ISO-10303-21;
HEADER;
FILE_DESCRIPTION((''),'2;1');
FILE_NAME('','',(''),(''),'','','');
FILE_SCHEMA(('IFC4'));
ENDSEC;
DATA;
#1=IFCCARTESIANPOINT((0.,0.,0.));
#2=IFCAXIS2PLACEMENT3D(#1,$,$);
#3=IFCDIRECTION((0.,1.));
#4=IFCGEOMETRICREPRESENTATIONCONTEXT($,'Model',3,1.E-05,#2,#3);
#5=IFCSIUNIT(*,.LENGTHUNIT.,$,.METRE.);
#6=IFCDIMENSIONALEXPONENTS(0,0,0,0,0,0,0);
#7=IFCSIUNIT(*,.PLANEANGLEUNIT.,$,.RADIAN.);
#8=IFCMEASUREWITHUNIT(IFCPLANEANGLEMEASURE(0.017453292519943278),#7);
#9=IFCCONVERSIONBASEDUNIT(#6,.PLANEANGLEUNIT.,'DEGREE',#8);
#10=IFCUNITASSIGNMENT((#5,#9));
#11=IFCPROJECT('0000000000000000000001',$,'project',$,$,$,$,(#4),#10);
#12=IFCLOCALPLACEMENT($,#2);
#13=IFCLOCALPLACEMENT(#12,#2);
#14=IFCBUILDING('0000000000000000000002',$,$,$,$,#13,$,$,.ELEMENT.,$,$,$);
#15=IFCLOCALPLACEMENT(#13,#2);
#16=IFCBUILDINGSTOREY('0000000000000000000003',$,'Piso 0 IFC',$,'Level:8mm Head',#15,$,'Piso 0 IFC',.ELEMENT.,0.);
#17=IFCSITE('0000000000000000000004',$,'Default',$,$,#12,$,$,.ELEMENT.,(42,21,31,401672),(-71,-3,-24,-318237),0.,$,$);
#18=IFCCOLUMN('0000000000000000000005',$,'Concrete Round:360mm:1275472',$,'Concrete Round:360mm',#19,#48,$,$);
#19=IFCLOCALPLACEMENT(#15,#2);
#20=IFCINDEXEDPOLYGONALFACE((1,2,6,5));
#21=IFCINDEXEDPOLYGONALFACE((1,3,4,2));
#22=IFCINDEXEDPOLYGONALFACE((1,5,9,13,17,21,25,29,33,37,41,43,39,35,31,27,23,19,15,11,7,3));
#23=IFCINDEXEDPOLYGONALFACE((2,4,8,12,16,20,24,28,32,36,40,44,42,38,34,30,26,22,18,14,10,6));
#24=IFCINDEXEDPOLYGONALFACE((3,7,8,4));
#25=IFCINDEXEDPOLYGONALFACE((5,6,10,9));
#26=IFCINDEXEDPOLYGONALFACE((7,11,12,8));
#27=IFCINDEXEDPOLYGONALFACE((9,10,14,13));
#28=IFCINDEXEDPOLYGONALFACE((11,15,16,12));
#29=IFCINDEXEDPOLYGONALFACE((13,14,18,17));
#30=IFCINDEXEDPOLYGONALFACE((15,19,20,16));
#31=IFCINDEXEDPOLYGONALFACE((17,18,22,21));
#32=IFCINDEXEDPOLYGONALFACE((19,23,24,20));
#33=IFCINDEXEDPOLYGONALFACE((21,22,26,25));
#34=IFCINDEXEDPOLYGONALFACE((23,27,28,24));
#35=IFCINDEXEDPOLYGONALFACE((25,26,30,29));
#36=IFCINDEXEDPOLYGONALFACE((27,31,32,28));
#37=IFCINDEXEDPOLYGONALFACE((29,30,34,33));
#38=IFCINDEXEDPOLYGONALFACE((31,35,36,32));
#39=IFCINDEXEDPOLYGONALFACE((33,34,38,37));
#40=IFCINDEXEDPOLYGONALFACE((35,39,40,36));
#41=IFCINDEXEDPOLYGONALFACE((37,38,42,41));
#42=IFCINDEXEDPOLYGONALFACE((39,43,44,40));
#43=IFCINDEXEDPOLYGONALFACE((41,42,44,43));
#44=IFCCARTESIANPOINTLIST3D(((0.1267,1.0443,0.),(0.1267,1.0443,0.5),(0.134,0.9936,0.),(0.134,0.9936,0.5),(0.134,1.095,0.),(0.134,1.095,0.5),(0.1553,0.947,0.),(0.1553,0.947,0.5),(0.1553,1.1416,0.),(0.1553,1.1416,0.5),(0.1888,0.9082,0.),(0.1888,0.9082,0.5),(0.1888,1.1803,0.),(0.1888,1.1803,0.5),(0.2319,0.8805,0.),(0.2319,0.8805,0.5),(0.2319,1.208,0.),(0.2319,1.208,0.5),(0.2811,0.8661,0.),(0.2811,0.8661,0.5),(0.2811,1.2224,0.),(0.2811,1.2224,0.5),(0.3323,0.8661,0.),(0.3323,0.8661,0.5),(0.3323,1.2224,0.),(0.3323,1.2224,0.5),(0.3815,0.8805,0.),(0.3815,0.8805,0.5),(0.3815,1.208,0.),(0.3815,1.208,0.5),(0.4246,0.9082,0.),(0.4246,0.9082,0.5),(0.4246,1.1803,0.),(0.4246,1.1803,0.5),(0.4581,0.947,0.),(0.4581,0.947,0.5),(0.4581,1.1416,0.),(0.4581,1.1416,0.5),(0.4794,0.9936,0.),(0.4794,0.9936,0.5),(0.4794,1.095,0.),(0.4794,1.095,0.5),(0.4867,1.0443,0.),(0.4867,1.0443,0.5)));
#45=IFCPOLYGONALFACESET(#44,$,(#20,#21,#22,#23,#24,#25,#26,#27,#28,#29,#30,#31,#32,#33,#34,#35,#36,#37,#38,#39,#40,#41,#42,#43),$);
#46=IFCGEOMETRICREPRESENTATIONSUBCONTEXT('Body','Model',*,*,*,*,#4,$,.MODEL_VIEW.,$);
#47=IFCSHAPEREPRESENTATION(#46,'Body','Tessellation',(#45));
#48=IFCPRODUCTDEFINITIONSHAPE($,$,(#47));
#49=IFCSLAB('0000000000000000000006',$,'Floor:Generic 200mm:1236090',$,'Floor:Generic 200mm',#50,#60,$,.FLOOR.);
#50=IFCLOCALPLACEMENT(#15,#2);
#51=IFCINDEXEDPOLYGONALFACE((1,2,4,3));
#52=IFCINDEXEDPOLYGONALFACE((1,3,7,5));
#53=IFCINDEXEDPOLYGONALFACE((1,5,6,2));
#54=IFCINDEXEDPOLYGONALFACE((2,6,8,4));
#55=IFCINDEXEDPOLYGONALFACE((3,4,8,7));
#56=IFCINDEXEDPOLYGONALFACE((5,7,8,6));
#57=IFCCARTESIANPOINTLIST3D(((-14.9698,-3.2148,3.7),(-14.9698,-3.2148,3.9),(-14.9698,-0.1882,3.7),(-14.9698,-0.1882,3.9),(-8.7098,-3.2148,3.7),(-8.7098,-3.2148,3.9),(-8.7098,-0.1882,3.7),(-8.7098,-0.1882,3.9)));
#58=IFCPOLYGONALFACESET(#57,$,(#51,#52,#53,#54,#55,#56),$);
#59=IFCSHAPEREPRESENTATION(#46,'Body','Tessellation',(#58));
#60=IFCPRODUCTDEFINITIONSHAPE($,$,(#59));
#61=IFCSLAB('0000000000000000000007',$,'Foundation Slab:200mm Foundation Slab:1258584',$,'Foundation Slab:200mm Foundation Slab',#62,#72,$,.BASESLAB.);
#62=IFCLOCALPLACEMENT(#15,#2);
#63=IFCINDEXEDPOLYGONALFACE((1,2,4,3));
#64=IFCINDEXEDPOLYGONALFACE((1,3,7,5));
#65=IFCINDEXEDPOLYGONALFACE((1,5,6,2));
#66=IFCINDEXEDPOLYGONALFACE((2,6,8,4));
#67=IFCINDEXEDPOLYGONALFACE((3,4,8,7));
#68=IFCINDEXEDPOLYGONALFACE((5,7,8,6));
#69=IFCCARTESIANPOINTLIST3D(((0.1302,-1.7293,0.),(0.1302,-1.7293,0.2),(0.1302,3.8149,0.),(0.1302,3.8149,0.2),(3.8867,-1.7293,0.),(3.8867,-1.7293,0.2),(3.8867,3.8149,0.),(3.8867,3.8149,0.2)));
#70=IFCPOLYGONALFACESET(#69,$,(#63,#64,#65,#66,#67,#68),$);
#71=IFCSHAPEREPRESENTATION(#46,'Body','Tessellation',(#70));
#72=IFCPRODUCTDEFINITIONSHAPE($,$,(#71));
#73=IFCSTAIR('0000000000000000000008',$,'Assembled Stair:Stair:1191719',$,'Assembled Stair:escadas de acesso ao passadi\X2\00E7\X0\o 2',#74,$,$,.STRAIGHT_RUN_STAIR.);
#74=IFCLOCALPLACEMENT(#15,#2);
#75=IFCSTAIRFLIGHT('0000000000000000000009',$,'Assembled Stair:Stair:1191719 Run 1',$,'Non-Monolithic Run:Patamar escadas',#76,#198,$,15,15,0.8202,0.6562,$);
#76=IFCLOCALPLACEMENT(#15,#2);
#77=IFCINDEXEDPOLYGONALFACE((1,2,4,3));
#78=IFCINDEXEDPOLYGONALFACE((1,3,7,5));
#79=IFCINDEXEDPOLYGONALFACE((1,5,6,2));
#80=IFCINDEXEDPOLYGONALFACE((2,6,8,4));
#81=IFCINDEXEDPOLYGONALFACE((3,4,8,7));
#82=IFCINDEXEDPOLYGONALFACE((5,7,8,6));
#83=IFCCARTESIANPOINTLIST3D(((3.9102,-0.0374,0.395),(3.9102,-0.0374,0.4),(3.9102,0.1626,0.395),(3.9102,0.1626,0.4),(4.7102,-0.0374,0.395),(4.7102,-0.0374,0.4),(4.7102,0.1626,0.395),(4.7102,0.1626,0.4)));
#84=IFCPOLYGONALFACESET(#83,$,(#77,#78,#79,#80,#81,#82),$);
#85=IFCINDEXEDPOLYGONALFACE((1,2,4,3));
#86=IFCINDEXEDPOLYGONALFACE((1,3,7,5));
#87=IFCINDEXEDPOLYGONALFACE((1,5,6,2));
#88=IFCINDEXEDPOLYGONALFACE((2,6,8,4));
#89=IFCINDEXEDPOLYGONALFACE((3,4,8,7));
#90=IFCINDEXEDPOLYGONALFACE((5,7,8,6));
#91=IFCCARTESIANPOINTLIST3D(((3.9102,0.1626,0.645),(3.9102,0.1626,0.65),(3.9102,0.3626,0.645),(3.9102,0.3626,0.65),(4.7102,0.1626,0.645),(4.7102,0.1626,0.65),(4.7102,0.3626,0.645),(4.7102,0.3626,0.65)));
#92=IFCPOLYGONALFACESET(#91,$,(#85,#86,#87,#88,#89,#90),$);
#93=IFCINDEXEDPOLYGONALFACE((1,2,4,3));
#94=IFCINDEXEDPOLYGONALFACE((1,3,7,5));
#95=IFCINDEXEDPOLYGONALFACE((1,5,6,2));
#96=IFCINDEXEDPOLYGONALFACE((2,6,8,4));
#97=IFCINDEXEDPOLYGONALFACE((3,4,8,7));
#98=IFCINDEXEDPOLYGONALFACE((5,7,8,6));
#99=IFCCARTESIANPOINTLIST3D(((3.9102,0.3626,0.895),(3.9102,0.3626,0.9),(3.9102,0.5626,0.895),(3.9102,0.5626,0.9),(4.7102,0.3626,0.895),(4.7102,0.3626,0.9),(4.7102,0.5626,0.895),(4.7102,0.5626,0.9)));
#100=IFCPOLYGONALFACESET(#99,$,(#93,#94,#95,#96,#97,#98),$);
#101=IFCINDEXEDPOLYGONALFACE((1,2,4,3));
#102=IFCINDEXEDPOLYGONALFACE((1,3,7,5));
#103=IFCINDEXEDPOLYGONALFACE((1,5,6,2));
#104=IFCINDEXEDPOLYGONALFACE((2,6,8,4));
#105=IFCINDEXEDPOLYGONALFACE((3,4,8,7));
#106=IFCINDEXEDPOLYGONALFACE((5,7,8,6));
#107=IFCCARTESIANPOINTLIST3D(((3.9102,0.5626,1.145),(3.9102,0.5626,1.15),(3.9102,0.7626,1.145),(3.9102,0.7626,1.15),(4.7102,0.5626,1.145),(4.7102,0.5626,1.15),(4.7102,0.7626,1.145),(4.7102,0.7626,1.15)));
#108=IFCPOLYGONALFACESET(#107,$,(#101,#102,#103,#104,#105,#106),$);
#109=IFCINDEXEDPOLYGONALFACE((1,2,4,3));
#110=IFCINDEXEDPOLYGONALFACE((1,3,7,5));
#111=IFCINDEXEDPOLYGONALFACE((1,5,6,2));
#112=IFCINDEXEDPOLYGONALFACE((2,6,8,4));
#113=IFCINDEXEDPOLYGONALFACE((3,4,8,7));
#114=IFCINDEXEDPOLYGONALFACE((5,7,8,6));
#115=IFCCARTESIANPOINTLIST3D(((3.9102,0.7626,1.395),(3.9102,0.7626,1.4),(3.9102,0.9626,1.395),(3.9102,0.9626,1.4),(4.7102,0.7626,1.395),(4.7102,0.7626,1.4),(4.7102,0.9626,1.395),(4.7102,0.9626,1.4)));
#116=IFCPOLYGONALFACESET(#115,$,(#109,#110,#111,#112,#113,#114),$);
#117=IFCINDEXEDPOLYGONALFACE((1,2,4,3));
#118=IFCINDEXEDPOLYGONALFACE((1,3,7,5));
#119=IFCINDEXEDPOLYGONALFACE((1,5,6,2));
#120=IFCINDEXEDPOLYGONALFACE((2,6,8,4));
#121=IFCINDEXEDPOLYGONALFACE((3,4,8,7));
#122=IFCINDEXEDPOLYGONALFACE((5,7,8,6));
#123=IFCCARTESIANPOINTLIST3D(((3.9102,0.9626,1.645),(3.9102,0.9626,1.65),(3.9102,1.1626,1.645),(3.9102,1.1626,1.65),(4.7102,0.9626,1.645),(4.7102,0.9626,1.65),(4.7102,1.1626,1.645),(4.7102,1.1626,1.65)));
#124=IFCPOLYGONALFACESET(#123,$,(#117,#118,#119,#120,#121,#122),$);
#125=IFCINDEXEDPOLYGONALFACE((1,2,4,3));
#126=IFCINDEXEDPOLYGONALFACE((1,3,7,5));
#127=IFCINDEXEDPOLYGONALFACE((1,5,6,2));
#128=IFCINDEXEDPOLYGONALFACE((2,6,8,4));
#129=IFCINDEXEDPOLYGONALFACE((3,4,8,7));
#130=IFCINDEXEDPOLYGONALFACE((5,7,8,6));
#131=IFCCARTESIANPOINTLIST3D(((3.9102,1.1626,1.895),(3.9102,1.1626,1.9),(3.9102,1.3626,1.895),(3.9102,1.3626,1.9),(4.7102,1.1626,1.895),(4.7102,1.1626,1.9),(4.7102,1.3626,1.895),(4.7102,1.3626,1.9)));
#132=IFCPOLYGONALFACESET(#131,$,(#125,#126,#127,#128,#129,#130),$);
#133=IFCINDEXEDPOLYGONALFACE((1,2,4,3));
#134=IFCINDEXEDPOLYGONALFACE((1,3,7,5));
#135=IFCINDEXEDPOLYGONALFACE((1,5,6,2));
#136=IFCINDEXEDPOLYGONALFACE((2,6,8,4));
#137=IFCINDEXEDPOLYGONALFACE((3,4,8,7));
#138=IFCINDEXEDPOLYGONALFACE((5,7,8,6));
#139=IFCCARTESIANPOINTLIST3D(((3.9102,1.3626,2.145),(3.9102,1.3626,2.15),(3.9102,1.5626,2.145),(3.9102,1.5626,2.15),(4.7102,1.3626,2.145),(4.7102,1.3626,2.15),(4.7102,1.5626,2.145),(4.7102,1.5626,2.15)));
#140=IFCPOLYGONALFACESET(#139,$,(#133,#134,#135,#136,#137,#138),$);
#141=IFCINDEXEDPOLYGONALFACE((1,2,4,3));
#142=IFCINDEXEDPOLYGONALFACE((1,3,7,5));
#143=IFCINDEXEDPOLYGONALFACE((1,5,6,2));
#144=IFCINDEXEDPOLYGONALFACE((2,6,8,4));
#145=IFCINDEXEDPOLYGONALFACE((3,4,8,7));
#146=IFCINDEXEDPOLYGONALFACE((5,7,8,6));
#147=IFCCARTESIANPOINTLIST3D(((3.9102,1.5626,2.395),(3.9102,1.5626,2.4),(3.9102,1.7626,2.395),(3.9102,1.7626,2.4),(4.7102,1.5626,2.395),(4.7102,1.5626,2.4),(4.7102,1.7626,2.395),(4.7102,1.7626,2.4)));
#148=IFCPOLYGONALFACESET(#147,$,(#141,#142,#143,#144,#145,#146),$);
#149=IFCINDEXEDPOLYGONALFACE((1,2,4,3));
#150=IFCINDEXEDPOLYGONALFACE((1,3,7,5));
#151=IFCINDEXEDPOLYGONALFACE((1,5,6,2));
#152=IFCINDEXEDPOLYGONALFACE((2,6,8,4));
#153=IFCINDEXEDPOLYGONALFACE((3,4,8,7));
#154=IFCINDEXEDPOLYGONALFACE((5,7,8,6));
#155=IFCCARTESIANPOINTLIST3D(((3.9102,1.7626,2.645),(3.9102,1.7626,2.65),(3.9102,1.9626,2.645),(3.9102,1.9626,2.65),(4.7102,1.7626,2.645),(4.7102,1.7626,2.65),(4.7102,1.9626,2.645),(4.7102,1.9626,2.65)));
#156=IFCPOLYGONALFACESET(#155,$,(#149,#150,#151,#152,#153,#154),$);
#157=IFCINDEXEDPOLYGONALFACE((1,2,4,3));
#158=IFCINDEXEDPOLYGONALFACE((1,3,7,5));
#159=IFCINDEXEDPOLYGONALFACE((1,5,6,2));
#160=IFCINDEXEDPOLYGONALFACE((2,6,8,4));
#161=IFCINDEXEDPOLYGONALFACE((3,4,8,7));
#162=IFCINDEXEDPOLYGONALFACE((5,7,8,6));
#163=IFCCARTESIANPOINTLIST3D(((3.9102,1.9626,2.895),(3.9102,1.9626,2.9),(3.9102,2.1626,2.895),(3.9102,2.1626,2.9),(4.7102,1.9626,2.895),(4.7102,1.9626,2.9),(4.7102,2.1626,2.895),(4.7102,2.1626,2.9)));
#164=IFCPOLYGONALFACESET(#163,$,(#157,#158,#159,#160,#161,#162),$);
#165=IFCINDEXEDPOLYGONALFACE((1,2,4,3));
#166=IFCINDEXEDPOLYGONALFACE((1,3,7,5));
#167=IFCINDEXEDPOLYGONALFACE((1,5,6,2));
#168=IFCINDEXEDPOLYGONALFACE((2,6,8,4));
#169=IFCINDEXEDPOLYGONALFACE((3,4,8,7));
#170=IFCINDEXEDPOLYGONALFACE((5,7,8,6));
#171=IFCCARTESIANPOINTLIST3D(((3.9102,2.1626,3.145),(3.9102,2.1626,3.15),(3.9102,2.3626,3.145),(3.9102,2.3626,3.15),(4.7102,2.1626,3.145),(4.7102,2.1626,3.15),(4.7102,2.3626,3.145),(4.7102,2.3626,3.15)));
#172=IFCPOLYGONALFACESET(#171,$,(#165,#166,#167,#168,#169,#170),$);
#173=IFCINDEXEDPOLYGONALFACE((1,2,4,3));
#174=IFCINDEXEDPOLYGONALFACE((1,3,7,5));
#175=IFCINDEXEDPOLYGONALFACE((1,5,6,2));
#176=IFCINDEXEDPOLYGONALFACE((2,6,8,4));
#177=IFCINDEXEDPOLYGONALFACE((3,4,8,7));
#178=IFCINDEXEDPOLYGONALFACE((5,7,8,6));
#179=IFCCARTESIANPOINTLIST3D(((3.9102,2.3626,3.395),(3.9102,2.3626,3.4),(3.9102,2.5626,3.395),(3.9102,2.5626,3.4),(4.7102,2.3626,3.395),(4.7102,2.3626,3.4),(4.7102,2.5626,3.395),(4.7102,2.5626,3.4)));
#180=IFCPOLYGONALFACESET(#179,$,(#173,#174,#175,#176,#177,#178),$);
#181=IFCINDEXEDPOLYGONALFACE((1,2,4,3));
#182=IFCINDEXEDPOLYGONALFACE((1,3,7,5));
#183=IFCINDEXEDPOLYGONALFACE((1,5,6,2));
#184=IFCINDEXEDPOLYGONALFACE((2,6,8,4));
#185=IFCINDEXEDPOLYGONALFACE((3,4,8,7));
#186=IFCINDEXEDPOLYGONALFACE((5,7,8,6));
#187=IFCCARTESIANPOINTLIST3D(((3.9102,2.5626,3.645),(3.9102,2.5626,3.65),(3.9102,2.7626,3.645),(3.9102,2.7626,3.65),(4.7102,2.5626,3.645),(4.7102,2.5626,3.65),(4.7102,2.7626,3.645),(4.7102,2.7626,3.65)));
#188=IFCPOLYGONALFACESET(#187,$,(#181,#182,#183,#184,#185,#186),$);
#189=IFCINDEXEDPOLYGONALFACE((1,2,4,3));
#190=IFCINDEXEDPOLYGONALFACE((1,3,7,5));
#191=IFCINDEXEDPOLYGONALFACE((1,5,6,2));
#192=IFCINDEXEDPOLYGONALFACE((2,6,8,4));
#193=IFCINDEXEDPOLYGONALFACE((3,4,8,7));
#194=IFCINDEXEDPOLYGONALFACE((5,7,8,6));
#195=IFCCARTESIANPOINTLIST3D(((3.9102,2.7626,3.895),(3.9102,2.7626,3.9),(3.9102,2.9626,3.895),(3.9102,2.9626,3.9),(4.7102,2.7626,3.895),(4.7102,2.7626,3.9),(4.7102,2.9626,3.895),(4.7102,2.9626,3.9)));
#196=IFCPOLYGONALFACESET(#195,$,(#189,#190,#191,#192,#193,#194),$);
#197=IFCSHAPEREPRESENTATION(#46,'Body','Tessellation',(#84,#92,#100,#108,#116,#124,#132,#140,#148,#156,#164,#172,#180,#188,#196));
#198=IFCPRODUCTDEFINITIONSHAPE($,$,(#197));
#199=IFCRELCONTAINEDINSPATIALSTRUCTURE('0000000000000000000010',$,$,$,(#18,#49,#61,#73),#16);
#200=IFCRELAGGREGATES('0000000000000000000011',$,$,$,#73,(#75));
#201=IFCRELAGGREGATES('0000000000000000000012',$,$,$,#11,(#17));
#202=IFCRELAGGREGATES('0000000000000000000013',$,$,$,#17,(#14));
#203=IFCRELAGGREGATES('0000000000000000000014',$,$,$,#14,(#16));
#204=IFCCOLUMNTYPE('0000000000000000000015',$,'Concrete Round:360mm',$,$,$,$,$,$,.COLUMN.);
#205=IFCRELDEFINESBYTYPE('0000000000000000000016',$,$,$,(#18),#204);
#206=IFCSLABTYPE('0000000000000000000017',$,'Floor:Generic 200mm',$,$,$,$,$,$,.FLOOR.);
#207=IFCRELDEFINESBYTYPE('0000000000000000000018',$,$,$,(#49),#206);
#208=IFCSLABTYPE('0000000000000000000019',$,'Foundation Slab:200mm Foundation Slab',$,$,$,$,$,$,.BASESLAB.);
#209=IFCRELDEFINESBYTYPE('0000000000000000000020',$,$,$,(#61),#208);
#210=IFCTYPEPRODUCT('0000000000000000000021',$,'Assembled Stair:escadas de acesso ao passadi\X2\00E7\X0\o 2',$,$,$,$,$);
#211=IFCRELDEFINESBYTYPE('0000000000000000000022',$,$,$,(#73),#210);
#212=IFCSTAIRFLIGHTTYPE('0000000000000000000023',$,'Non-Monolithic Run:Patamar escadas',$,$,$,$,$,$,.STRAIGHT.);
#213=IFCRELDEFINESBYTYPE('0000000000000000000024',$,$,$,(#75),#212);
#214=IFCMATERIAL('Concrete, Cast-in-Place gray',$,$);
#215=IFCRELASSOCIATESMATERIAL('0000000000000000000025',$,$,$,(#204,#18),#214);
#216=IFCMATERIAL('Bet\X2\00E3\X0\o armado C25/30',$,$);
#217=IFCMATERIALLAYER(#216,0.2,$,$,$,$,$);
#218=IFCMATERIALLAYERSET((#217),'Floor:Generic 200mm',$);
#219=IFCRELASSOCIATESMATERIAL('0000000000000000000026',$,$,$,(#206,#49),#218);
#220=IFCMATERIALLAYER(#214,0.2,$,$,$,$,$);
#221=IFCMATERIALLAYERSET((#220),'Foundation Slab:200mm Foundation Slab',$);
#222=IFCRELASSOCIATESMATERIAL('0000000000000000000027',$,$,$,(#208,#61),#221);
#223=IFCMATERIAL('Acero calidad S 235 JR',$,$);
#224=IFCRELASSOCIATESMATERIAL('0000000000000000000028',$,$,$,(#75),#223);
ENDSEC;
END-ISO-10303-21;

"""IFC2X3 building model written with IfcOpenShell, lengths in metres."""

from ifc_helpers import new_model, entity, si_unit, converted_unit, direction, frame, frame_2d, origin, origin_2d_with_axis, place, context, subcontext, project, spatial, rectangle, circle, extrude, source, transform, mapped, material, layer, layer_set, layer_usage, type_object, type_shapes, element, aggregate, save


model = new_model("IFC2X3")

# Units and contexts
model_context = context("Model", 3, precision=1e-05, world=origin(), true_north=direction((0.0, 1.0)))
body_context = subcontext(model_context, "Body", "Model", "MODEL_VIEW")
ifc_project = project(units=[si_unit("LENGTHUNIT", "METRE"), converted_unit("PLANEANGLEUNIT", "DEGREE", entity("IfcPlaneAngleMeasure", 0.017453292519943278), si_unit("PLANEANGLEUNIT", "RADIAN"), dimensions=[0, 0, 0, 0, 0, 0, 0])], contexts=[model_context])

# Site, building, storey
site_placement = place(None, origin())
site = spatial("IfcSite", under=ifc_project, at=site_placement, Name="Default", CompositionType="ELEMENT", RefLatitude=(42, 21, 31, 401672), RefLongitude=(-71, -3, -24, -318237), RefElevation=0.0)
building_placement = place(site_placement, origin())
building = spatial("IfcBuilding", under=site, at=building_placement, CompositionType="ELEMENT")
storey_placement = place(building_placement, origin())
storey = spatial("IfcBuildingStorey", under=building, at=storey_placement, Name="Piso 0 IFC", ObjectType="Level:8mm Head", LongName="Piso 0 IFC", CompositionType="ELEMENT", Elevation=0.0)

# Column
ifc_material_1 = material(Name="Concrete, Cast-in-Place gray")
column_type_1 = type_object("IfcColumnType", Name="Concrete Round:360mm", PredefinedType="COLUMN", material=ifc_material_1)
shared_shape_1 = source(origin(), body_context, "Body", "SweptSolid", [
    extrude(circle(Radius=0.18, at=frame_2d((0.0, 0.0), x_axis=(1.0, 0.0))), frame((0.3067, 1.0443, 0.0)), (0.0, 0.0, 1.0), 0.5),
])
type_shapes(column_type_1, [shared_shape_1])
column_1_placement = place(storey_placement, origin())
element("IfcColumn", 1, at=column_1_placement, inside=storey, type_object=column_type_1, material=ifc_material_1, Name="Concrete Round:360mm:1275472", ObjectType="Concrete Round:360mm", context=body_context, shape_type="MappedRepresentation", body=[
    mapped(shared_shape_1, transform((0.0, 0.0, 0.0), scale=1.0)),
])

# Slabs
ifc_material_2 = material(Name="Betão armado C25/30")
ifc_layer_1 = layer(ifc_material_2, 0.2)
ifc_layer_set_1 = layer_set([ifc_layer_1], Name="Floor:Generic 200mm")
slab_type_1 = type_object("IfcSlabType", Name="Floor:Generic 200mm", PredefinedType="FLOOR", material=ifc_layer_set_1)
ifc_layer_usage_1 = layer_usage(ifc_layer_set_1, "AXIS3", "POSITIVE", 0.0)
slab_1_placement = place(storey_placement, origin())
element("IfcSlab", 2, at=slab_1_placement, inside=storey, type_object=slab_type_1, material=ifc_layer_usage_1, Name="Floor:Generic 200mm:1236090", ObjectType="Floor:Generic 200mm", PredefinedType="FLOOR", context=body_context, shape_type="SweptSolid", body=[
    extrude(rectangle(XDim=3.0266, YDim=6.26, at=frame_2d((0.0, 0.0), x_axis=(1.0, 0.0))), frame((-11.8398, -1.7015, 3.9), z_axis=(0.0, 0.0, -1.0), x_axis=(0.0, 1.0, 0.0)), (0.0, 0.0, 1.0), 0.2),
])
ifc_layer_2 = layer(ifc_material_1, 0.2)
ifc_layer_set_2 = layer_set([ifc_layer_2], Name="Foundation Slab:200mm Foundation Slab")
ifc_layer_usage_2 = layer_usage(ifc_layer_set_2, "AXIS3", "POSITIVE", 0.0)
slab_type_2 = type_object("IfcSlabType", Name="Foundation Slab:200mm Foundation Slab", PredefinedType="BASESLAB", material=ifc_layer_set_2)
slab_2_placement = place(storey_placement, origin())
element("IfcSlab", 3, at=slab_2_placement, inside=storey, type_object=slab_type_2, material=ifc_layer_usage_2, Name="Foundation Slab:200mm Foundation Slab:1258584", ObjectType="Foundation Slab:200mm Foundation Slab", PredefinedType="BASESLAB", context=body_context, shape_type="SweptSolid", body=[
    extrude(rectangle(XDim=5.5441, YDim=3.7565, at=origin_2d_with_axis()), frame((2.0084, 1.0428, 0.2), z_axis=(0.0, 0.0, -1.0), x_axis=(0.0, 1.0, 0.0)), (0.0, 0.0, 1.0), 0.2),
])

# Stair, stair flight
type_product = type_object("IfcTypeProduct", Name="Assembled Stair:escadas de acesso ao passadiço 2")
stair_placement = place(storey_placement, origin())
stair = element("IfcStair", 4, at=stair_placement, inside=storey, type_object=type_product, Name="Assembled Stair:Stair:1191719", ObjectType="Assembled Stair:escadas de acesso ao passadiço 2", ShapeType="STRAIGHT_RUN_STAIR")
ifc_material_3 = material(Name="Acero calidad S 235 JR")
stair_flight_type = type_object("IfcStairFlightType", Name="Non-Monolithic Run:Patamar escadas", PredefinedType="STRAIGHT")
stair_flight_placement = place(stair_placement, origin())
stair_flight = element("IfcStairFlight", 5, at=stair_flight_placement, type_object=stair_flight_type, material=ifc_material_3, Name="Assembled Stair:Stair:1191719 Run 1", ObjectType="Non-Monolithic Run:Patamar escadas", NumberOfRiser=15, NumberOfTreads=15, RiserHeight=0.8202, TreadLength=0.6562, context=body_context, shape_type="SweptSolid", body=[
    extrude(rectangle(XDim=0.2, YDim=0.8, at=frame_2d((0.0, 0.0), x_axis=(1.0, 0.0))), frame((4.3102, 0.0626, 0.395), z_axis=(0.0, 0.0, 1.0), x_axis=(0.0, -1.0, 0.0)), (0.0, 0.0, 1.0), 0.005),
    extrude(rectangle(XDim=0.2, YDim=0.8, at=origin_2d_with_axis()), frame((4.3102, 0.2626, 0.645), z_axis=(0.0, 0.0, 1.0), x_axis=(0.0, -1.0, 0.0)), (0.0, 0.0, 1.0), 0.005),
    extrude(rectangle(XDim=0.2, YDim=0.8, at=origin_2d_with_axis()), frame((4.3102, 0.4626, 0.895), z_axis=(0.0, 0.0, 1.0), x_axis=(0.0, -1.0, 0.0)), (0.0, 0.0, 1.0), 0.005),
    extrude(rectangle(XDim=0.2, YDim=0.8, at=origin_2d_with_axis()), frame((4.3102, 0.6626, 1.145), z_axis=(0.0, 0.0, 1.0), x_axis=(0.0, -1.0, 0.0)), (0.0, 0.0, 1.0), 0.005),
    extrude(rectangle(XDim=0.2, YDim=0.8, at=origin_2d_with_axis()), frame((4.3102, 0.8626, 1.395), z_axis=(0.0, 0.0, 1.0), x_axis=(0.0, -1.0, 0.0)), (0.0, 0.0, 1.0), 0.005),
    extrude(rectangle(XDim=0.2, YDim=0.8, at=origin_2d_with_axis()), frame((4.3102, 1.0626, 1.645), z_axis=(0.0, 0.0, 1.0), x_axis=(0.0, -1.0, 0.0)), (0.0, 0.0, 1.0), 0.005),
    extrude(rectangle(XDim=0.2, YDim=0.8, at=frame_2d((0.0, 0.0), x_axis=(1.0, 0.0))), frame((4.3102, 1.2626, 1.895), z_axis=(0.0, 0.0, 1.0), x_axis=(0.0, -1.0, 0.0)), (0.0, 0.0, 1.0), 0.005),
    extrude(rectangle(XDim=0.2, YDim=0.8, at=origin_2d_with_axis()), frame((4.3102, 1.4626, 2.145), z_axis=(0.0, 0.0, 1.0), x_axis=(0.0, -1.0, 0.0)), (0.0, 0.0, 1.0), 0.005),
    extrude(rectangle(XDim=0.2, YDim=0.8, at=origin_2d_with_axis()), frame((4.3102, 1.6626, 2.395), z_axis=(0.0, 0.0, 1.0), x_axis=(0.0, -1.0, 0.0)), (0.0, 0.0, 1.0), 0.005),
    extrude(rectangle(XDim=0.2, YDim=0.8, at=origin_2d_with_axis()), frame((4.3102, 1.8626, 2.645), z_axis=(0.0, 0.0, 1.0), x_axis=(0.0, -1.0, 0.0)), (0.0, 0.0, 1.0), 0.005),
    extrude(rectangle(XDim=0.2, YDim=0.8, at=origin_2d_with_axis()), frame((4.3102, 2.0626, 2.895), z_axis=(0.0, 0.0, 1.0), x_axis=(0.0, -1.0, 0.0)), (0.0, 0.0, 1.0), 0.005),
    extrude(rectangle(XDim=0.2, YDim=0.8, at=origin_2d_with_axis()), frame((4.3102, 2.2626, 3.145), z_axis=(0.0, 0.0, 1.0), x_axis=(0.0, -1.0, 0.0)), (0.0, 0.0, 1.0), 0.005),
    extrude(rectangle(XDim=0.2, YDim=0.8, at=origin_2d_with_axis()), frame((4.3102, 2.4626, 3.395), z_axis=(0.0, 0.0, 1.0), x_axis=(0.0, -1.0, 0.0)), (0.0, 0.0, 1.0), 0.005),
    extrude(rectangle(XDim=0.2, YDim=0.8, at=origin_2d_with_axis()), frame((4.3102, 2.6626, 3.645), z_axis=(0.0, 0.0, 1.0), x_axis=(0.0, -1.0, 0.0)), (0.0, 0.0, 1.0), 0.005),
    extrude(rectangle(XDim=0.2, YDim=0.8, at=origin_2d_with_axis()), frame((4.3102, 2.8626, 3.895), z_axis=(0.0, 0.0, 1.0), x_axis=(0.0, -1.0, 0.0)), (0.0, 0.0, 1.0), 0.005),
])
aggregate(stair, [stair_flight])

save(model, "model.ifc")
